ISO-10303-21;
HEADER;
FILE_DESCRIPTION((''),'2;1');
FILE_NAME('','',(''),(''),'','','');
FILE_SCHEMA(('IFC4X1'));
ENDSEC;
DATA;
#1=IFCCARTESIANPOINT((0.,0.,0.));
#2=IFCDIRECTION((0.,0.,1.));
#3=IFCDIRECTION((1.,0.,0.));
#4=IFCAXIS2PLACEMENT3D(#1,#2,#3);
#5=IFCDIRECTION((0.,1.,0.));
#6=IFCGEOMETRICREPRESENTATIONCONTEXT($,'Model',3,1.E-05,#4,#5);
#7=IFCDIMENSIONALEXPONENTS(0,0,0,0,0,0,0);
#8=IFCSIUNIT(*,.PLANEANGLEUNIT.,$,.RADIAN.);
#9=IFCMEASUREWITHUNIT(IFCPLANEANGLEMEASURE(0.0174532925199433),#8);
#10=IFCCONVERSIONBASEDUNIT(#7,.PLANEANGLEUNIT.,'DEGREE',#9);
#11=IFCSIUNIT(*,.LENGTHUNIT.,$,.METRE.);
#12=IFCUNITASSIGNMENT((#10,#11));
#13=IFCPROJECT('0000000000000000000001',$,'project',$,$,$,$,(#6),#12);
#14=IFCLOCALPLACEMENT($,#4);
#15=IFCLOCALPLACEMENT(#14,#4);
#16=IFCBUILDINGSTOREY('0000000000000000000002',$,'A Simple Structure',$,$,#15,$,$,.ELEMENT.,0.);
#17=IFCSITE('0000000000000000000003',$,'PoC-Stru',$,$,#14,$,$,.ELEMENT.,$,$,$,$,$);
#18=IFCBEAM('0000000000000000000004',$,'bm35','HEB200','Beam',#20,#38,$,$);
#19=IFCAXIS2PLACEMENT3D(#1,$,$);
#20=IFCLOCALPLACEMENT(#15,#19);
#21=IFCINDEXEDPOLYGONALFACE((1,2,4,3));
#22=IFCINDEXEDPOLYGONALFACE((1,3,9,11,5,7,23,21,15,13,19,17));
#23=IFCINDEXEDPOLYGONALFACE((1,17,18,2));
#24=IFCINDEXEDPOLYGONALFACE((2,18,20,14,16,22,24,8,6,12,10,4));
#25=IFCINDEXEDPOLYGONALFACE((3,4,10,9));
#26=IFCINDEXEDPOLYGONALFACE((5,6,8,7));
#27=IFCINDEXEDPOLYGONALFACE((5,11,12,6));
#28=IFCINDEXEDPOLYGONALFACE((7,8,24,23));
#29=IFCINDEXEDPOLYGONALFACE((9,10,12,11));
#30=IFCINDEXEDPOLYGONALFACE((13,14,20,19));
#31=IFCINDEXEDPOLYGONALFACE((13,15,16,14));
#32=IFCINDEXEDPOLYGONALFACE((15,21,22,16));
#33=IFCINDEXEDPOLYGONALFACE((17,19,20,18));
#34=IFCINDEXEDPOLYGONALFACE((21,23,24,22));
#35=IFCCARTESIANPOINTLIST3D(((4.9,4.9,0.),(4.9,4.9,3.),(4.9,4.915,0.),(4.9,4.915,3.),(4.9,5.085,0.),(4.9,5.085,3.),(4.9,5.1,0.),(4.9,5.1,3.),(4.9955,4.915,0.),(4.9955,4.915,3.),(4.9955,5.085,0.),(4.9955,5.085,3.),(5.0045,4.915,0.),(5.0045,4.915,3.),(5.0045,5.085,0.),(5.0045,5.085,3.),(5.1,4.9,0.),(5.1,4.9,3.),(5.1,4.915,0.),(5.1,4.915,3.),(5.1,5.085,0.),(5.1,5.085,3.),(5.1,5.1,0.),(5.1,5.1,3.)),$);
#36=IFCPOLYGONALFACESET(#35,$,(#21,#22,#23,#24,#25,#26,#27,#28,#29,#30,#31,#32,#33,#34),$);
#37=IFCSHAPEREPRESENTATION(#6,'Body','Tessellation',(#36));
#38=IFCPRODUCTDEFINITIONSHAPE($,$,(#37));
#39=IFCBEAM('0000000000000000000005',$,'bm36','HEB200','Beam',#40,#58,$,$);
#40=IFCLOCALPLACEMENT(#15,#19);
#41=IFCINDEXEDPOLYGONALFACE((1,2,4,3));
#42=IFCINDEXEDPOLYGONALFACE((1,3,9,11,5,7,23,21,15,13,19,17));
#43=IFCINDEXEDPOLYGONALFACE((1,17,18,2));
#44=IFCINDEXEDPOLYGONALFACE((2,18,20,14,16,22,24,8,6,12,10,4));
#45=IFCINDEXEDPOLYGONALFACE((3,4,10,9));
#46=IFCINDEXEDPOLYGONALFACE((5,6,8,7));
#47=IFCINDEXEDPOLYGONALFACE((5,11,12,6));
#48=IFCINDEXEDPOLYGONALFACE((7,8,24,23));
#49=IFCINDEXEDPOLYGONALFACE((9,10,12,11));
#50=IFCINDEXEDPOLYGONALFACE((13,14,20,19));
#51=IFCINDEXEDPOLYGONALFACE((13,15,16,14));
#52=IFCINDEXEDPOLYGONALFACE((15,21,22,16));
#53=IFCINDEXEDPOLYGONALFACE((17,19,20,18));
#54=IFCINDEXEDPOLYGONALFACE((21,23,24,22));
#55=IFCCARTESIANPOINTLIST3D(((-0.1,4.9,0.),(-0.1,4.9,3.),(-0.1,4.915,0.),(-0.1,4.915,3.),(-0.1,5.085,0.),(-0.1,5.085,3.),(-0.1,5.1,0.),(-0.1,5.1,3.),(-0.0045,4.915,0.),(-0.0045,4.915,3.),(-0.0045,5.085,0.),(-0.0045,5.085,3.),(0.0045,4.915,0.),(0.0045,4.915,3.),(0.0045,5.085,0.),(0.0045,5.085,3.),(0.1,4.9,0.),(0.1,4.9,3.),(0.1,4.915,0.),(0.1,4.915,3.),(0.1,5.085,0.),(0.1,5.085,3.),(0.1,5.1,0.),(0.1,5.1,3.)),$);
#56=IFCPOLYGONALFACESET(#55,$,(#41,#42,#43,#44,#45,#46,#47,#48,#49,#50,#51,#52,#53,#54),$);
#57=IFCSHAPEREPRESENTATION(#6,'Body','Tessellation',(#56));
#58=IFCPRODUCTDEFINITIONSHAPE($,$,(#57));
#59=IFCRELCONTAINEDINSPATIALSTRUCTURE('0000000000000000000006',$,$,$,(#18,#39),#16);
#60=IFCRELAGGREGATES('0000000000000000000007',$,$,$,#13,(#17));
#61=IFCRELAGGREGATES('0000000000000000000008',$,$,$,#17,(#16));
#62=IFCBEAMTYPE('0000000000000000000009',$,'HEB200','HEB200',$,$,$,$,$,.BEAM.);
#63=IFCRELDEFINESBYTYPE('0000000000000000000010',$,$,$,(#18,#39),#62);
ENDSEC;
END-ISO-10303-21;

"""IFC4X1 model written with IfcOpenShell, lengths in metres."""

from ifc_helpers import new_model, entity, si_unit, converted_unit, direction, frame, origin, origin_with_axes, place, context, project, spatial, i_section, extrude, type_object, element, save


model = new_model("IFC4X1")

# Units and contexts
model_context = context("Model", 3, precision=1e-05, world=origin_with_axes(), true_north=direction((0.0, 1.0, 0.0)))
ifc_project = project(units=[converted_unit("PLANEANGLEUNIT", "DEGREE", entity("IfcPlaneAngleMeasure", 0.0174532925199433), si_unit("PLANEANGLEUNIT", "RADIAN"), dimensions=[0, 0, 0, 0, 0, 0, 0]), si_unit("LENGTHUNIT", "METRE")], contexts=[model_context])

# Site, storey
site_placement = place(None, origin_with_axes())
site = spatial("IfcSite", under=ifc_project, at=site_placement, Name="PoC-Stru", CompositionType="ELEMENT")
storey_placement = place(site_placement, origin_with_axes())
storey = spatial("IfcBuildingStorey", under=site, at=storey_placement, Name="A Simple Structure", CompositionType="ELEMENT", Elevation=0.0)

# Beams
placement = place(storey_placement, origin_with_axes())
beam_type_1 = type_object("IfcBeamType", Name="HEB200", Description="HEB200", PredefinedType="BEAM")
for number, where, z_axis, x_axis, name in (
    (1, (5.0, 5.0, 0.0), (0.0, 0.0, 1.0), (1.0, 0.0, 0.0), "bm35"),
    (2, (0.0, 5.0, 0.0), (0.0, 0.0, 1.0), (1.0, 0.0, 0.0), "bm36"),
):
    element("IfcBeam", number, at=place(placement, frame(where, z_axis=z_axis, x_axis=x_axis)), inside=storey, type_object=beam_type_1, Name=name, Description="HEB200", ObjectType="Beam", context=model_context, shape_type="SweptSolid", body=[
        extrude(i_section(OverallWidth=0.2, OverallDepth=0.2, WebThickness=0.009, FlangeThickness=0.015), origin(), (0.0, 0.0, 1.0), 3.0),
    ])

save(model, "model.ifc")
